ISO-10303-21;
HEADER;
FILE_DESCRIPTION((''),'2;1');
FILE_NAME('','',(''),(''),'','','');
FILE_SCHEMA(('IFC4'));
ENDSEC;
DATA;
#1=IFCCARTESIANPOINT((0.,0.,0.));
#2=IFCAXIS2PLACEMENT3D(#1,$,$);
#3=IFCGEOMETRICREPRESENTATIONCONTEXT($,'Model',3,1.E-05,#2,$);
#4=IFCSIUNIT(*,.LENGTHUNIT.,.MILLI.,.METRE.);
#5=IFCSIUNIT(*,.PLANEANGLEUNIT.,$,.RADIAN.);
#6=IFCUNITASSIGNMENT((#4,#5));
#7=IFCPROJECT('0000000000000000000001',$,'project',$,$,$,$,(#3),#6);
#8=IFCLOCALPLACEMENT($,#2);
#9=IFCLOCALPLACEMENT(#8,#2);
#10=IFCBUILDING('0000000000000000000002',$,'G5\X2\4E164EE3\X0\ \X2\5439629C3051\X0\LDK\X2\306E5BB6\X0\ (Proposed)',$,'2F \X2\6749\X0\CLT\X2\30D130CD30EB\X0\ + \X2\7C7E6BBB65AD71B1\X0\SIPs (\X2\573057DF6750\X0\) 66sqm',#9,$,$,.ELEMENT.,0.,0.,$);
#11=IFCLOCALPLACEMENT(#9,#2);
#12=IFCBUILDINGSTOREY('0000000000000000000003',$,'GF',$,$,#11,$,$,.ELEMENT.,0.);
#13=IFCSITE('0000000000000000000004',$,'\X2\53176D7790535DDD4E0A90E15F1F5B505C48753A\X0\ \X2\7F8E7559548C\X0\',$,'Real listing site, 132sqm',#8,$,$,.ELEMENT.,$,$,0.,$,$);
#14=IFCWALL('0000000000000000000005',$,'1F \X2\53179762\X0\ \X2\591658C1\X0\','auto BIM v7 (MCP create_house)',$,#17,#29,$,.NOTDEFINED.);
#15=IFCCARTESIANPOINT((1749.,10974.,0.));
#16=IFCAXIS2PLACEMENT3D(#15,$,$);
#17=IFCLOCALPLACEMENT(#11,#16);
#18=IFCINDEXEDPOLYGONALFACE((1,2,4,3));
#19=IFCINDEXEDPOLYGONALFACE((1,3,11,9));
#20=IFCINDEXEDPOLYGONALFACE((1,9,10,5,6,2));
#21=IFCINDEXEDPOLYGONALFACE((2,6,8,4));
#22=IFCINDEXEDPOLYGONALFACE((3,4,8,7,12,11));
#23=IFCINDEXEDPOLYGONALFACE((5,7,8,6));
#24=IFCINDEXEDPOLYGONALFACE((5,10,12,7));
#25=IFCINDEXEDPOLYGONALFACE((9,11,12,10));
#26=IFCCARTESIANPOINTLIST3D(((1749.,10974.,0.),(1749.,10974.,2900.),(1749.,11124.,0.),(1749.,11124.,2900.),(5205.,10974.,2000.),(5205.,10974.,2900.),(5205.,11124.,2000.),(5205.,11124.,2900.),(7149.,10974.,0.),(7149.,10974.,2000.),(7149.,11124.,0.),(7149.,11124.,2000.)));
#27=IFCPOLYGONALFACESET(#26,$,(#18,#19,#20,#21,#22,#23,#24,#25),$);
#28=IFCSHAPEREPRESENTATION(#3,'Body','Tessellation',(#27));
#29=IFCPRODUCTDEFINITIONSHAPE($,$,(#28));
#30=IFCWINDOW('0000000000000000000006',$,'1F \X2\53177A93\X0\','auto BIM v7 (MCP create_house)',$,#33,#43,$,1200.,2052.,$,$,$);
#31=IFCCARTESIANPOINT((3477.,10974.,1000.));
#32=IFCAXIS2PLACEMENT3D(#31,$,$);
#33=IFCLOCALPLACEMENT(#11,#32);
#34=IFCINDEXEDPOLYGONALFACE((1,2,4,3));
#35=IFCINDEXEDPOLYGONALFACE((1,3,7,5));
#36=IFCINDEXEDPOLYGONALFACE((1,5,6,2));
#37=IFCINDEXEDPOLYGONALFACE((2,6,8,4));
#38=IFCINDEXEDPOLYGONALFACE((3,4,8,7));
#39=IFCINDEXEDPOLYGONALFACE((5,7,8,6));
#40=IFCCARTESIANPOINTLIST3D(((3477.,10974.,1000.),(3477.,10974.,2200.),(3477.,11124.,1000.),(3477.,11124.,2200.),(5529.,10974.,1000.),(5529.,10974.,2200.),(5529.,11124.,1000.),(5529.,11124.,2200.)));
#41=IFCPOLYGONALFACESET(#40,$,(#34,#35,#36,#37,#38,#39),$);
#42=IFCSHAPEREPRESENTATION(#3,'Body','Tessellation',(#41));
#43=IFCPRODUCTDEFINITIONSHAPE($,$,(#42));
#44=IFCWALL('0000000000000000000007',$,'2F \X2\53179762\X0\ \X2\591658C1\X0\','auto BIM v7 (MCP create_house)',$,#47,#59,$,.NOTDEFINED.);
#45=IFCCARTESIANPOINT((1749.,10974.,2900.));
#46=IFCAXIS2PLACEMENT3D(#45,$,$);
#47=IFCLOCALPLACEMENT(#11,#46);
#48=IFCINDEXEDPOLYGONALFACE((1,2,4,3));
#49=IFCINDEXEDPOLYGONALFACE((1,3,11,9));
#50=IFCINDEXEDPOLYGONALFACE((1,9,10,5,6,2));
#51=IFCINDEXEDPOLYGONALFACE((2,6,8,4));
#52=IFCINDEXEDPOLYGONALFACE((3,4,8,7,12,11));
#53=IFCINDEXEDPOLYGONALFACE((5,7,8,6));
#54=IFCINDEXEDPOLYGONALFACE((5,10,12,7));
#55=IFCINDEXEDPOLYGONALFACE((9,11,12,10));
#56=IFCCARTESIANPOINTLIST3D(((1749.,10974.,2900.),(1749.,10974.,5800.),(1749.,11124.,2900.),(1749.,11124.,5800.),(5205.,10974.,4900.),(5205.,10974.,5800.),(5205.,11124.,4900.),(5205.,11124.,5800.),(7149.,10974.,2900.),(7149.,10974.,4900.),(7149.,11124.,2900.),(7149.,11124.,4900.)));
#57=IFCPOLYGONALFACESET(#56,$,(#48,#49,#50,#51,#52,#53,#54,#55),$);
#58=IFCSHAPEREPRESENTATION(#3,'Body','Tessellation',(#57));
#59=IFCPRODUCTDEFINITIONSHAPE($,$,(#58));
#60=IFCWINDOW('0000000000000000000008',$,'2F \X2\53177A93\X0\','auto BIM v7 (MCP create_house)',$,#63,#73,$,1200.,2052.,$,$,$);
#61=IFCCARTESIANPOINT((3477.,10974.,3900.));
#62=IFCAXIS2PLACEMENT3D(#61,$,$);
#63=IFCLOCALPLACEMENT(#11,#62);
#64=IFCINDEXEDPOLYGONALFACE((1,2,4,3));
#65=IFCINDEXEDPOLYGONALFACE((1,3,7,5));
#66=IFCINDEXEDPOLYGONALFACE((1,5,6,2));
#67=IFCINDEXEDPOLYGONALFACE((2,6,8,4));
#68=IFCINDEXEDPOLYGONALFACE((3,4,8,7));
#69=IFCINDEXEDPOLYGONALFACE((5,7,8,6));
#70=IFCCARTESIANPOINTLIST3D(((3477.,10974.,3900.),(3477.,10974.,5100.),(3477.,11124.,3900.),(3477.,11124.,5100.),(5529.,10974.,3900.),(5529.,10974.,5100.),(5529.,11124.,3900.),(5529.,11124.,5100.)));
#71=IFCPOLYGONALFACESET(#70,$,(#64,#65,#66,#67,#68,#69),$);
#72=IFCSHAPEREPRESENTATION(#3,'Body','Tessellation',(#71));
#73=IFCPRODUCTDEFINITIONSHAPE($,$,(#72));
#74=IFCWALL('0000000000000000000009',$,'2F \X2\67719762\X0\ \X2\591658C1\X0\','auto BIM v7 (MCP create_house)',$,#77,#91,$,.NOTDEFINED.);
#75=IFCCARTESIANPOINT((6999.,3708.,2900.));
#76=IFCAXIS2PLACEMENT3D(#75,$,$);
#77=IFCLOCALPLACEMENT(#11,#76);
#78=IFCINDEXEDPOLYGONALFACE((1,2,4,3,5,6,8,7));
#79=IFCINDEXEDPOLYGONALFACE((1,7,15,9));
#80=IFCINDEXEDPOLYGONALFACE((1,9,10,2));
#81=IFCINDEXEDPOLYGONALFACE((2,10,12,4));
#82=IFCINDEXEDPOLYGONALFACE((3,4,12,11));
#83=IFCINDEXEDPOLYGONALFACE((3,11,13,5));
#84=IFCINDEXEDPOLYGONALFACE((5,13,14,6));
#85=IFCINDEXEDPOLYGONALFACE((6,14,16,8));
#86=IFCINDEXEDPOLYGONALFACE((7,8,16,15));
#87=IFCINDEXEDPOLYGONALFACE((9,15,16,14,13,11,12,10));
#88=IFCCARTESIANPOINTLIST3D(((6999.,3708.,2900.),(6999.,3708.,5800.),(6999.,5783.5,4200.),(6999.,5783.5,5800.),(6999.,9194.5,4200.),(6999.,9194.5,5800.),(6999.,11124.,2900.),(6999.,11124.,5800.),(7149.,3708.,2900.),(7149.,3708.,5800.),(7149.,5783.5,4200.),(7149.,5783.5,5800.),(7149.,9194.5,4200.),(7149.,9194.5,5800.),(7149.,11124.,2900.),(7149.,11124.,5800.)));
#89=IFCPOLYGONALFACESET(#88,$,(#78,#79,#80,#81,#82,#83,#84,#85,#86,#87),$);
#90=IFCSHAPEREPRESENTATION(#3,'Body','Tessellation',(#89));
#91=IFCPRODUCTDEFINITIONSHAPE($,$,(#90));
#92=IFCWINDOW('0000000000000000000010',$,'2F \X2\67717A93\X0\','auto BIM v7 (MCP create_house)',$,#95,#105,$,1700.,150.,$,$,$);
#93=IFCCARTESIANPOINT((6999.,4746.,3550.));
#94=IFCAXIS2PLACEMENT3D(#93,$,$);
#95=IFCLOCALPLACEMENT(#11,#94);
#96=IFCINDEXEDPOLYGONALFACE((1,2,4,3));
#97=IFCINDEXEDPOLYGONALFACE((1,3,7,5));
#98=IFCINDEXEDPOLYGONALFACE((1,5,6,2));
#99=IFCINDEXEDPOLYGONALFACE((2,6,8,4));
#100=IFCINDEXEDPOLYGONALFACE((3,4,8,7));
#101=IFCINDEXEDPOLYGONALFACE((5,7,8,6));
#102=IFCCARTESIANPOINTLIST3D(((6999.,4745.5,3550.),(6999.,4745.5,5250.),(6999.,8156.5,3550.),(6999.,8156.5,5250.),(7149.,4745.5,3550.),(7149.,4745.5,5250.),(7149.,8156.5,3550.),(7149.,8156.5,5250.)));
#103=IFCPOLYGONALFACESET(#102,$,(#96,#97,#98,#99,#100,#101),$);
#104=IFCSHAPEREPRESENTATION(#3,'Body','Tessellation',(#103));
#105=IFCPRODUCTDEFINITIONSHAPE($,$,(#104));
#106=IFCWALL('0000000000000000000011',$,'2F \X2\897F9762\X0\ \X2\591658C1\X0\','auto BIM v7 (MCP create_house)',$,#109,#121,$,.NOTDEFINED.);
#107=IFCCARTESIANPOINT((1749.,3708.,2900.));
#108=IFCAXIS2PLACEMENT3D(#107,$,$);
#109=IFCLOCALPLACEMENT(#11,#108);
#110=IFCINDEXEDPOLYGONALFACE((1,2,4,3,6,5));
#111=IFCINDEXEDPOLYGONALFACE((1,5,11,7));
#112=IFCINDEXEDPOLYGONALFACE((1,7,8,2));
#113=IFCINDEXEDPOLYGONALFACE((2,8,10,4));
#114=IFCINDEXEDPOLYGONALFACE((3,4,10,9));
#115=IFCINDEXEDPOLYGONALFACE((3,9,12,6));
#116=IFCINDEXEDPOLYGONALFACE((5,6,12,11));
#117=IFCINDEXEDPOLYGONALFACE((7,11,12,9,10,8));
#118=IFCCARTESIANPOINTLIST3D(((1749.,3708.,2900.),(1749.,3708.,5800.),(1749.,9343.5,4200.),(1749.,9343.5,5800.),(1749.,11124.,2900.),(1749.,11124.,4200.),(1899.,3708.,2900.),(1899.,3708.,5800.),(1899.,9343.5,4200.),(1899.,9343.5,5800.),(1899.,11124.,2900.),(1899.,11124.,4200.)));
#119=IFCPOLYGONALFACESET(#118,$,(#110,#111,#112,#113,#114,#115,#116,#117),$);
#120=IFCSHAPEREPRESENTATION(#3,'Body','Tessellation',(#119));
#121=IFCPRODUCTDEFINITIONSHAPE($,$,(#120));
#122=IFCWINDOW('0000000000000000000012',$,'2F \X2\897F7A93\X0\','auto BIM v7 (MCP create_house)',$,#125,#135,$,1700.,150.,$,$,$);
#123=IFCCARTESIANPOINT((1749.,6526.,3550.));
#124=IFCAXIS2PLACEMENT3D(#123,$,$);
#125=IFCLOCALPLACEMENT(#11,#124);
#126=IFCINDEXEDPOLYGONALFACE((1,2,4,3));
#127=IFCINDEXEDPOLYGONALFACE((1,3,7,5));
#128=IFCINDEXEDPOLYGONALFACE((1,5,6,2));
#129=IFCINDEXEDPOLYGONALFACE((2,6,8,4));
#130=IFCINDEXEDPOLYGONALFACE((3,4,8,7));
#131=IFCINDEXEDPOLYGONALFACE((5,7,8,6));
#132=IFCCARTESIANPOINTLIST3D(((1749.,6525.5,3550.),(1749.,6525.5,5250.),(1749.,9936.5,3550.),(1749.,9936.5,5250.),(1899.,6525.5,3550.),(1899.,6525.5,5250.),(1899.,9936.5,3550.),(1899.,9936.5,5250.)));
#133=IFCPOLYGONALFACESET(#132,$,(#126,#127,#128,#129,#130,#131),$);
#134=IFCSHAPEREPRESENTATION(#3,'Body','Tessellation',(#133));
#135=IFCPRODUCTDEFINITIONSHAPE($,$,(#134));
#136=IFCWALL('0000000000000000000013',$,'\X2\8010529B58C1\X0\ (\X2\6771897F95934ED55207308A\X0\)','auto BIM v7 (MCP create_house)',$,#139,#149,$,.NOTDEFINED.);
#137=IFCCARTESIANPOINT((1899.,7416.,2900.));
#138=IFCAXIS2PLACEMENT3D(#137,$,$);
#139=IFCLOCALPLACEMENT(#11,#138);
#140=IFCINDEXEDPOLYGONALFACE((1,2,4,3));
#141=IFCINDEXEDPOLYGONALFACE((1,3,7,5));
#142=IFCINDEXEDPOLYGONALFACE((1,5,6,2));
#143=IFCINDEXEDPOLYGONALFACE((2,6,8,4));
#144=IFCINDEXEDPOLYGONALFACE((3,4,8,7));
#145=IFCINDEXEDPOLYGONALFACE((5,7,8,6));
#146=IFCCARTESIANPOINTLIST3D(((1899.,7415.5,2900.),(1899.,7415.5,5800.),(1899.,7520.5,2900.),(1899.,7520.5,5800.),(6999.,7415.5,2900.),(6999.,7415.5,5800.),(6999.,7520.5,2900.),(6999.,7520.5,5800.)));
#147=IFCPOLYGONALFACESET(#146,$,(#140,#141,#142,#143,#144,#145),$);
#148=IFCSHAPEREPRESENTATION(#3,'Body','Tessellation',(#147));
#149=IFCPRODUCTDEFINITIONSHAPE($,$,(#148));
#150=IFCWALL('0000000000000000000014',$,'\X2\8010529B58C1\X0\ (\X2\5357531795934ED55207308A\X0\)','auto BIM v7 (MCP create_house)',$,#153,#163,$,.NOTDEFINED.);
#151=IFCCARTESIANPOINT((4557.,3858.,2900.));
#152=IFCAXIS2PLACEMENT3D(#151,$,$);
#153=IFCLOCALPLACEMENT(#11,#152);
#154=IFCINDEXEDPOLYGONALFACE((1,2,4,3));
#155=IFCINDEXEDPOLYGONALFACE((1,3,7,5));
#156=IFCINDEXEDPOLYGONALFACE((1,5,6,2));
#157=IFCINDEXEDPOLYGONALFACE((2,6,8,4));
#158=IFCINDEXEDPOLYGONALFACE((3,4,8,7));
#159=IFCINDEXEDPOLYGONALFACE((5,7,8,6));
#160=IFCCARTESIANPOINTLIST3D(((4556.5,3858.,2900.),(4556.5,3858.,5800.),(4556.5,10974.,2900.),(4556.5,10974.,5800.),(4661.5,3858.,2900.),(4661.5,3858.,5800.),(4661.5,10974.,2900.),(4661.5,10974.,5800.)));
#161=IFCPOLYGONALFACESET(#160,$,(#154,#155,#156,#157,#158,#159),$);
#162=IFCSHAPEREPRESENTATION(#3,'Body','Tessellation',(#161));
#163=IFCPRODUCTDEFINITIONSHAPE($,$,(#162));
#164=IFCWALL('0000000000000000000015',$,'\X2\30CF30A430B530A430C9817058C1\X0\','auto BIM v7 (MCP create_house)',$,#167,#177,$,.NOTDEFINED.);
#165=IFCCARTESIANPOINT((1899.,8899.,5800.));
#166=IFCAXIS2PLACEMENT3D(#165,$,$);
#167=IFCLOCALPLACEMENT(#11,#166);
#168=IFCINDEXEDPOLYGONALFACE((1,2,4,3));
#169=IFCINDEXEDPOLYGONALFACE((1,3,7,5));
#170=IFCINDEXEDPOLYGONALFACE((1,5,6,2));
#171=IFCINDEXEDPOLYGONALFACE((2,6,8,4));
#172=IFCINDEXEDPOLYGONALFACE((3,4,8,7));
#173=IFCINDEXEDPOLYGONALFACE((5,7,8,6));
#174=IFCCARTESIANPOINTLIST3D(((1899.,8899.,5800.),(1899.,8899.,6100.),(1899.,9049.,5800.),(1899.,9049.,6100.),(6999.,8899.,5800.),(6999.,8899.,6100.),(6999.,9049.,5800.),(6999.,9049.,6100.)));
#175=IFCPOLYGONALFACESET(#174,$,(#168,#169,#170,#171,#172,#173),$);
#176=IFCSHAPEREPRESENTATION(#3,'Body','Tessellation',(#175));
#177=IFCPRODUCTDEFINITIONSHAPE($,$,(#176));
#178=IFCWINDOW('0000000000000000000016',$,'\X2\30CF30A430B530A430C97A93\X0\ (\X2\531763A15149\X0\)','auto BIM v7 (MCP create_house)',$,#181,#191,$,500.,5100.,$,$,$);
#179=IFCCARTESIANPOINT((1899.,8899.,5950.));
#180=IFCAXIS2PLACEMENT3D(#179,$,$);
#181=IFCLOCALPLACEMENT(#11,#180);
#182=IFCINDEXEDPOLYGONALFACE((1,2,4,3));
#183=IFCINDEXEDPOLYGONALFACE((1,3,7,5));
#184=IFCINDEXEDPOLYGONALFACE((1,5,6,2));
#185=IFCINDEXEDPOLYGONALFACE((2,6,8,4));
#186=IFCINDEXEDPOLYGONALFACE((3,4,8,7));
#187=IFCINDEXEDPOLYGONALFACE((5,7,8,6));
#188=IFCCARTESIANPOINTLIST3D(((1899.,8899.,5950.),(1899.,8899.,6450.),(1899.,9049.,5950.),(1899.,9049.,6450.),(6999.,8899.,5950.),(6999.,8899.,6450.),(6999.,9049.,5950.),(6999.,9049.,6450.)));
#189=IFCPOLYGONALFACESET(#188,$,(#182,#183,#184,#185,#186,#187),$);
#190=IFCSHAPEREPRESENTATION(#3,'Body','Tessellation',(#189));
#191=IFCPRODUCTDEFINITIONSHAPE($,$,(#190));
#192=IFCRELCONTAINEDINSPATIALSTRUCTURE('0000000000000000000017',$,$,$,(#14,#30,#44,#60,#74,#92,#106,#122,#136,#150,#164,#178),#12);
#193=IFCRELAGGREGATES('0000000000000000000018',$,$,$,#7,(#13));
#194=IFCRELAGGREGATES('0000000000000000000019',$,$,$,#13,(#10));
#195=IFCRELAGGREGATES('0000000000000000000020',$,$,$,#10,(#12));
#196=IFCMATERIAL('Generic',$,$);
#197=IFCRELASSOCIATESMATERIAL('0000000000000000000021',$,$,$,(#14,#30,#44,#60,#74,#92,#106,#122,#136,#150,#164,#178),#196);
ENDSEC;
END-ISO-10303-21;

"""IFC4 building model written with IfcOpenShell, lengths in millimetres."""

from ifc_helpers import new_model, si_unit, frame, frame_2d, origin, place, context, project, spatial, rectangle, extrude, material, element, fill, save


model = new_model("IFC4")

# Units and contexts
model_context = context("Model", 3, precision=1e-05, world=origin())
ifc_project = project(units=[si_unit("LENGTHUNIT", "METRE", prefix="MILLI"), si_unit("PLANEANGLEUNIT", "RADIAN")], contexts=[model_context])

# Site, building, storey
site_placement = place(None, origin())
site = spatial("IfcSite", under=ifc_project, at=site_placement, Name="北海道川上郡弟子屈町 美留和", ObjectType="Real listing site, 132sqm", CompositionType="ELEMENT", RefElevation=0.0)
building_placement = place(site_placement, origin())
building = spatial("IfcBuilding", under=site, at=building_placement, Name="G5世代 吹抜けLDKの家 (Proposed)", ObjectType="2F 杉CLTパネル + 籾殻断熱SIPs (地域材) 66sqm", CompositionType="ELEMENT", ElevationOfRefHeight=0.0, ElevationOfTerrain=0.0)
storey_placement = place(building_placement, origin())
storey = spatial("IfcBuildingStorey", under=building, at=storey_placement, Name="GF", CompositionType="ELEMENT", Elevation=0.0)

# Wall, opening, window
ifc_material = material(Name="Generic")
wall_1_placement = place(storey_placement, frame((1749.0, 10974.0, 0.0)))
wall_1 = element("IfcWall", 1, at=wall_1_placement, inside=storey, material=ifc_material, Name="1F 北面 外壁", Description="auto BIM v7 (MCP create_house)", PredefinedType="NOTDEFINED", context=model_context, shape_type="SweptSolid", body=[
    extrude(rectangle(XDim=5400.0, YDim=150.0, at=frame_2d((2700.0, 75.0))), frame((1749.0, 10974.0, 0.0)), (0.0, 0.0, 1.0), 2900.0),
])
opening_1_placement = place(storey_placement, frame((3477.0, 10974.0, 1000.0)))
opening_1 = element("IfcOpeningElement", 2, at=opening_1_placement, cuts=wall_1, PredefinedType="NOTDEFINED", context=model_context, shape_type="SweptSolid", body=[
    extrude(rectangle(XDim=2052.0, YDim=150.0, at=frame_2d((1026.0, 75.0))), frame((3477.0, 10974.0, 1000.0)), (0.0, 0.0, 1.0), 1200.0),
])
window_1_placement = place(storey_placement, frame((3477.0, 10974.0, 1000.0)))
window_1 = element("IfcWindow", 3, at=window_1_placement, inside=storey, material=ifc_material, Name="1F 北窓", Description="auto BIM v7 (MCP create_house)", OverallHeight=1200.0, OverallWidth=2052.0, context=model_context, shape_type="SweptSolid", body=[
    extrude(rectangle(XDim=2052.0, YDim=150.0, at=frame_2d((1026.0, 75.0))), frame((3477.0, 10974.0, 1000.0)), (0.0, 0.0, 1.0), 1200.0),
])
fill(opening_1, window_1)

# Walls, openings, windows
wall_2_placement = place(storey_placement, frame((1749.0, 10974.0, 2900.0)))
wall_2 = element("IfcWall", 4, at=wall_2_placement, inside=storey, material=ifc_material, Name="2F 北面 外壁", Description="auto BIM v7 (MCP create_house)", PredefinedType="NOTDEFINED", context=model_context, shape_type="SweptSolid", body=[
    extrude(rectangle(XDim=5400.0, YDim=150.0, at=frame_2d((2700.0, 75.0))), frame((1749.0, 10974.0, 2900.0)), (0.0, 0.0, 1.0), 2900.0),
])
opening_2_placement = place(storey_placement, frame((3477.0, 10974.0, 3900.0)))
opening_2 = element("IfcOpeningElement", 5, at=opening_2_placement, cuts=wall_2, PredefinedType="NOTDEFINED", context=model_context, shape_type="SweptSolid", body=[
    extrude(rectangle(XDim=2052.0, YDim=150.0, at=frame_2d((1026.0, 75.0))), frame((3477.0, 10974.0, 3900.0)), (0.0, 0.0, 1.0), 1200.0),
])
window_2_placement = place(storey_placement, frame((3477.0, 10974.0, 3900.0)))
window_2 = element("IfcWindow", 6, at=window_2_placement, inside=storey, material=ifc_material, Name="2F 北窓", Description="auto BIM v7 (MCP create_house)", OverallHeight=1200.0, OverallWidth=2052.0, context=model_context, shape_type="SweptSolid", body=[
    extrude(rectangle(XDim=2052.0, YDim=150.0, at=frame_2d((1026.0, 75.0))), frame((3477.0, 10974.0, 3900.0)), (0.0, 0.0, 1.0), 1200.0),
])
fill(opening_2, window_2)
wall_3_placement = place(storey_placement, frame((6999.0, 3708.0, 2900.0)))
wall_3 = element("IfcWall", 7, at=wall_3_placement, inside=storey, material=ifc_material, Name="2F 東面 外壁", Description="auto BIM v7 (MCP create_house)", PredefinedType="NOTDEFINED", context=model_context, shape_type="SweptSolid", body=[
    extrude(rectangle(XDim=150.0, YDim=7416.0, at=frame_2d((75.0, 3708.0))), frame((6999.0, 3708.0, 2900.0)), (0.0, 0.0, 1.0), 2900.0),
])
opening_3_placement = place(storey_placement, frame((6999.0, 4746.0, 3550.0)))
opening_3 = element("IfcOpeningElement", 8, at=opening_3_placement, cuts=wall_3, PredefinedType="NOTDEFINED", context=model_context, shape_type="SweptSolid", body=[
    extrude(rectangle(XDim=150.0, YDim=3411.0, at=frame_2d((75.0, 1705.0))), frame((6999.0, 4746.0, 3550.0)), (0.0, 0.0, 1.0), 1700.0),
])
window_3_placement = place(storey_placement, frame((6999.0, 4746.0, 3550.0)))
window_3 = element("IfcWindow", 9, at=window_3_placement, inside=storey, material=ifc_material, Name="2F 東窓", Description="auto BIM v7 (MCP create_house)", OverallHeight=1700.0, OverallWidth=150.0, context=model_context, shape_type="SweptSolid", body=[
    extrude(rectangle(XDim=150.0, YDim=3411.0, at=frame_2d((75.0, 1705.0))), frame((6999.0, 4746.0, 3550.0)), (0.0, 0.0, 1.0), 1700.0),
])
fill(opening_3, window_3)
wall_4_placement = place(storey_placement, frame((1749.0, 3708.0, 2900.0)))
wall_4 = element("IfcWall", 10, at=wall_4_placement, inside=storey, material=ifc_material, Name="2F 西面 外壁", Description="auto BIM v7 (MCP create_house)", PredefinedType="NOTDEFINED", context=model_context, shape_type="SweptSolid", body=[
    extrude(rectangle(XDim=150.0, YDim=7416.0, at=frame_2d((75.0, 3708.0))), frame((1749.0, 3708.0, 2900.0)), (0.0, 0.0, 1.0), 2900.0),
])
opening_4_placement = place(storey_placement, frame((1749.0, 6526.0, 3550.0)))
opening_4 = element("IfcOpeningElement", 11, at=opening_4_placement, cuts=wall_4, PredefinedType="NOTDEFINED", context=model_context, shape_type="SweptSolid", body=[
    extrude(rectangle(XDim=150.0, YDim=3411.0, at=frame_2d((75.0, 1705.0))), frame((1749.0, 6526.0, 3550.0)), (0.0, 0.0, 1.0), 1700.0),
])
window_4_placement = place(storey_placement, frame((1749.0, 6526.0, 3550.0)))
window_4 = element("IfcWindow", 12, at=window_4_placement, inside=storey, material=ifc_material, Name="2F 西窓", Description="auto BIM v7 (MCP create_house)", OverallHeight=1700.0, OverallWidth=150.0, context=model_context, shape_type="SweptSolid", body=[
    extrude(rectangle(XDim=150.0, YDim=3411.0, at=frame_2d((75.0, 1705.0))), frame((1749.0, 6526.0, 3550.0)), (0.0, 0.0, 1.0), 1700.0),
])
fill(opening_4, window_4)

# Walls
wall_5_placement = place(storey_placement, frame((1899.0, 7416.0, 2900.0)))
element("IfcWall", 13, at=wall_5_placement, inside=storey, material=ifc_material, Name="耐力壁 (東西間仕切り)", Description="auto BIM v7 (MCP create_house)", PredefinedType="NOTDEFINED", context=model_context, shape_type="SweptSolid", body=[
    extrude(rectangle(XDim=5100.0, YDim=105.0, at=frame_2d((2550.0, 52.0))), frame((1899.0, 7416.0, 2900.0)), (0.0, 0.0, 1.0), 2900.0),
])
wall_6_placement = place(storey_placement, frame((4557.0, 3858.0, 2900.0)))
element("IfcWall", 14, at=wall_6_placement, inside=storey, material=ifc_material, Name="耐力壁 (南北間仕切り)", Description="auto BIM v7 (MCP create_house)", PredefinedType="NOTDEFINED", context=model_context, shape_type="SweptSolid", body=[
    extrude(rectangle(XDim=105.0, YDim=7116.0, at=frame_2d((52.0, 3558.0))), frame((4557.0, 3858.0, 2900.0)), (0.0, 0.0, 1.0), 2900.0),
])

# Wall, opening, window
wall_7_placement = place(storey_placement, frame((1899.0, 8899.0, 5800.0)))
wall_7 = element("IfcWall", 15, at=wall_7_placement, inside=storey, material=ifc_material, Name="ハイサイド腰壁", Description="auto BIM v7 (MCP create_house)", PredefinedType="NOTDEFINED", context=model_context, shape_type="SweptSolid", body=[
    extrude(rectangle(XDim=5100.0, YDim=150.0, at=frame_2d((2550.0, 75.0))), frame((1899.0, 8899.0, 5800.0)), (0.0, 0.0, 1.0), 700.0),
])
opening_5_placement = place(storey_placement, frame((1899.0, 8899.0, 5950.0)))
opening_5 = element("IfcOpeningElement", 16, at=opening_5_placement, cuts=wall_7, PredefinedType="NOTDEFINED", context=model_context, shape_type="SweptSolid", body=[
    extrude(rectangle(XDim=5100.0, YDim=150.0, at=frame_2d((2550.0, 75.0))), frame((1899.0, 8899.0, 5950.0)), (0.0, 0.0, 1.0), 500.0),
])
window_5_placement = place(storey_placement, frame((1899.0, 8899.0, 5950.0)))
window_5 = element("IfcWindow", 17, at=window_5_placement, inside=storey, material=ifc_material, Name="ハイサイド窓 (北採光)", Description="auto BIM v7 (MCP create_house)", OverallHeight=500.0, OverallWidth=5100.0, context=model_context, shape_type="SweptSolid", body=[
    extrude(rectangle(XDim=5100.0, YDim=150.0, at=frame_2d((2550.0, 75.0))), frame((1899.0, 8899.0, 5950.0)), (0.0, 0.0, 1.0), 500.0),
])
fill(opening_5, window_5)

save(model, "model.ifc")
